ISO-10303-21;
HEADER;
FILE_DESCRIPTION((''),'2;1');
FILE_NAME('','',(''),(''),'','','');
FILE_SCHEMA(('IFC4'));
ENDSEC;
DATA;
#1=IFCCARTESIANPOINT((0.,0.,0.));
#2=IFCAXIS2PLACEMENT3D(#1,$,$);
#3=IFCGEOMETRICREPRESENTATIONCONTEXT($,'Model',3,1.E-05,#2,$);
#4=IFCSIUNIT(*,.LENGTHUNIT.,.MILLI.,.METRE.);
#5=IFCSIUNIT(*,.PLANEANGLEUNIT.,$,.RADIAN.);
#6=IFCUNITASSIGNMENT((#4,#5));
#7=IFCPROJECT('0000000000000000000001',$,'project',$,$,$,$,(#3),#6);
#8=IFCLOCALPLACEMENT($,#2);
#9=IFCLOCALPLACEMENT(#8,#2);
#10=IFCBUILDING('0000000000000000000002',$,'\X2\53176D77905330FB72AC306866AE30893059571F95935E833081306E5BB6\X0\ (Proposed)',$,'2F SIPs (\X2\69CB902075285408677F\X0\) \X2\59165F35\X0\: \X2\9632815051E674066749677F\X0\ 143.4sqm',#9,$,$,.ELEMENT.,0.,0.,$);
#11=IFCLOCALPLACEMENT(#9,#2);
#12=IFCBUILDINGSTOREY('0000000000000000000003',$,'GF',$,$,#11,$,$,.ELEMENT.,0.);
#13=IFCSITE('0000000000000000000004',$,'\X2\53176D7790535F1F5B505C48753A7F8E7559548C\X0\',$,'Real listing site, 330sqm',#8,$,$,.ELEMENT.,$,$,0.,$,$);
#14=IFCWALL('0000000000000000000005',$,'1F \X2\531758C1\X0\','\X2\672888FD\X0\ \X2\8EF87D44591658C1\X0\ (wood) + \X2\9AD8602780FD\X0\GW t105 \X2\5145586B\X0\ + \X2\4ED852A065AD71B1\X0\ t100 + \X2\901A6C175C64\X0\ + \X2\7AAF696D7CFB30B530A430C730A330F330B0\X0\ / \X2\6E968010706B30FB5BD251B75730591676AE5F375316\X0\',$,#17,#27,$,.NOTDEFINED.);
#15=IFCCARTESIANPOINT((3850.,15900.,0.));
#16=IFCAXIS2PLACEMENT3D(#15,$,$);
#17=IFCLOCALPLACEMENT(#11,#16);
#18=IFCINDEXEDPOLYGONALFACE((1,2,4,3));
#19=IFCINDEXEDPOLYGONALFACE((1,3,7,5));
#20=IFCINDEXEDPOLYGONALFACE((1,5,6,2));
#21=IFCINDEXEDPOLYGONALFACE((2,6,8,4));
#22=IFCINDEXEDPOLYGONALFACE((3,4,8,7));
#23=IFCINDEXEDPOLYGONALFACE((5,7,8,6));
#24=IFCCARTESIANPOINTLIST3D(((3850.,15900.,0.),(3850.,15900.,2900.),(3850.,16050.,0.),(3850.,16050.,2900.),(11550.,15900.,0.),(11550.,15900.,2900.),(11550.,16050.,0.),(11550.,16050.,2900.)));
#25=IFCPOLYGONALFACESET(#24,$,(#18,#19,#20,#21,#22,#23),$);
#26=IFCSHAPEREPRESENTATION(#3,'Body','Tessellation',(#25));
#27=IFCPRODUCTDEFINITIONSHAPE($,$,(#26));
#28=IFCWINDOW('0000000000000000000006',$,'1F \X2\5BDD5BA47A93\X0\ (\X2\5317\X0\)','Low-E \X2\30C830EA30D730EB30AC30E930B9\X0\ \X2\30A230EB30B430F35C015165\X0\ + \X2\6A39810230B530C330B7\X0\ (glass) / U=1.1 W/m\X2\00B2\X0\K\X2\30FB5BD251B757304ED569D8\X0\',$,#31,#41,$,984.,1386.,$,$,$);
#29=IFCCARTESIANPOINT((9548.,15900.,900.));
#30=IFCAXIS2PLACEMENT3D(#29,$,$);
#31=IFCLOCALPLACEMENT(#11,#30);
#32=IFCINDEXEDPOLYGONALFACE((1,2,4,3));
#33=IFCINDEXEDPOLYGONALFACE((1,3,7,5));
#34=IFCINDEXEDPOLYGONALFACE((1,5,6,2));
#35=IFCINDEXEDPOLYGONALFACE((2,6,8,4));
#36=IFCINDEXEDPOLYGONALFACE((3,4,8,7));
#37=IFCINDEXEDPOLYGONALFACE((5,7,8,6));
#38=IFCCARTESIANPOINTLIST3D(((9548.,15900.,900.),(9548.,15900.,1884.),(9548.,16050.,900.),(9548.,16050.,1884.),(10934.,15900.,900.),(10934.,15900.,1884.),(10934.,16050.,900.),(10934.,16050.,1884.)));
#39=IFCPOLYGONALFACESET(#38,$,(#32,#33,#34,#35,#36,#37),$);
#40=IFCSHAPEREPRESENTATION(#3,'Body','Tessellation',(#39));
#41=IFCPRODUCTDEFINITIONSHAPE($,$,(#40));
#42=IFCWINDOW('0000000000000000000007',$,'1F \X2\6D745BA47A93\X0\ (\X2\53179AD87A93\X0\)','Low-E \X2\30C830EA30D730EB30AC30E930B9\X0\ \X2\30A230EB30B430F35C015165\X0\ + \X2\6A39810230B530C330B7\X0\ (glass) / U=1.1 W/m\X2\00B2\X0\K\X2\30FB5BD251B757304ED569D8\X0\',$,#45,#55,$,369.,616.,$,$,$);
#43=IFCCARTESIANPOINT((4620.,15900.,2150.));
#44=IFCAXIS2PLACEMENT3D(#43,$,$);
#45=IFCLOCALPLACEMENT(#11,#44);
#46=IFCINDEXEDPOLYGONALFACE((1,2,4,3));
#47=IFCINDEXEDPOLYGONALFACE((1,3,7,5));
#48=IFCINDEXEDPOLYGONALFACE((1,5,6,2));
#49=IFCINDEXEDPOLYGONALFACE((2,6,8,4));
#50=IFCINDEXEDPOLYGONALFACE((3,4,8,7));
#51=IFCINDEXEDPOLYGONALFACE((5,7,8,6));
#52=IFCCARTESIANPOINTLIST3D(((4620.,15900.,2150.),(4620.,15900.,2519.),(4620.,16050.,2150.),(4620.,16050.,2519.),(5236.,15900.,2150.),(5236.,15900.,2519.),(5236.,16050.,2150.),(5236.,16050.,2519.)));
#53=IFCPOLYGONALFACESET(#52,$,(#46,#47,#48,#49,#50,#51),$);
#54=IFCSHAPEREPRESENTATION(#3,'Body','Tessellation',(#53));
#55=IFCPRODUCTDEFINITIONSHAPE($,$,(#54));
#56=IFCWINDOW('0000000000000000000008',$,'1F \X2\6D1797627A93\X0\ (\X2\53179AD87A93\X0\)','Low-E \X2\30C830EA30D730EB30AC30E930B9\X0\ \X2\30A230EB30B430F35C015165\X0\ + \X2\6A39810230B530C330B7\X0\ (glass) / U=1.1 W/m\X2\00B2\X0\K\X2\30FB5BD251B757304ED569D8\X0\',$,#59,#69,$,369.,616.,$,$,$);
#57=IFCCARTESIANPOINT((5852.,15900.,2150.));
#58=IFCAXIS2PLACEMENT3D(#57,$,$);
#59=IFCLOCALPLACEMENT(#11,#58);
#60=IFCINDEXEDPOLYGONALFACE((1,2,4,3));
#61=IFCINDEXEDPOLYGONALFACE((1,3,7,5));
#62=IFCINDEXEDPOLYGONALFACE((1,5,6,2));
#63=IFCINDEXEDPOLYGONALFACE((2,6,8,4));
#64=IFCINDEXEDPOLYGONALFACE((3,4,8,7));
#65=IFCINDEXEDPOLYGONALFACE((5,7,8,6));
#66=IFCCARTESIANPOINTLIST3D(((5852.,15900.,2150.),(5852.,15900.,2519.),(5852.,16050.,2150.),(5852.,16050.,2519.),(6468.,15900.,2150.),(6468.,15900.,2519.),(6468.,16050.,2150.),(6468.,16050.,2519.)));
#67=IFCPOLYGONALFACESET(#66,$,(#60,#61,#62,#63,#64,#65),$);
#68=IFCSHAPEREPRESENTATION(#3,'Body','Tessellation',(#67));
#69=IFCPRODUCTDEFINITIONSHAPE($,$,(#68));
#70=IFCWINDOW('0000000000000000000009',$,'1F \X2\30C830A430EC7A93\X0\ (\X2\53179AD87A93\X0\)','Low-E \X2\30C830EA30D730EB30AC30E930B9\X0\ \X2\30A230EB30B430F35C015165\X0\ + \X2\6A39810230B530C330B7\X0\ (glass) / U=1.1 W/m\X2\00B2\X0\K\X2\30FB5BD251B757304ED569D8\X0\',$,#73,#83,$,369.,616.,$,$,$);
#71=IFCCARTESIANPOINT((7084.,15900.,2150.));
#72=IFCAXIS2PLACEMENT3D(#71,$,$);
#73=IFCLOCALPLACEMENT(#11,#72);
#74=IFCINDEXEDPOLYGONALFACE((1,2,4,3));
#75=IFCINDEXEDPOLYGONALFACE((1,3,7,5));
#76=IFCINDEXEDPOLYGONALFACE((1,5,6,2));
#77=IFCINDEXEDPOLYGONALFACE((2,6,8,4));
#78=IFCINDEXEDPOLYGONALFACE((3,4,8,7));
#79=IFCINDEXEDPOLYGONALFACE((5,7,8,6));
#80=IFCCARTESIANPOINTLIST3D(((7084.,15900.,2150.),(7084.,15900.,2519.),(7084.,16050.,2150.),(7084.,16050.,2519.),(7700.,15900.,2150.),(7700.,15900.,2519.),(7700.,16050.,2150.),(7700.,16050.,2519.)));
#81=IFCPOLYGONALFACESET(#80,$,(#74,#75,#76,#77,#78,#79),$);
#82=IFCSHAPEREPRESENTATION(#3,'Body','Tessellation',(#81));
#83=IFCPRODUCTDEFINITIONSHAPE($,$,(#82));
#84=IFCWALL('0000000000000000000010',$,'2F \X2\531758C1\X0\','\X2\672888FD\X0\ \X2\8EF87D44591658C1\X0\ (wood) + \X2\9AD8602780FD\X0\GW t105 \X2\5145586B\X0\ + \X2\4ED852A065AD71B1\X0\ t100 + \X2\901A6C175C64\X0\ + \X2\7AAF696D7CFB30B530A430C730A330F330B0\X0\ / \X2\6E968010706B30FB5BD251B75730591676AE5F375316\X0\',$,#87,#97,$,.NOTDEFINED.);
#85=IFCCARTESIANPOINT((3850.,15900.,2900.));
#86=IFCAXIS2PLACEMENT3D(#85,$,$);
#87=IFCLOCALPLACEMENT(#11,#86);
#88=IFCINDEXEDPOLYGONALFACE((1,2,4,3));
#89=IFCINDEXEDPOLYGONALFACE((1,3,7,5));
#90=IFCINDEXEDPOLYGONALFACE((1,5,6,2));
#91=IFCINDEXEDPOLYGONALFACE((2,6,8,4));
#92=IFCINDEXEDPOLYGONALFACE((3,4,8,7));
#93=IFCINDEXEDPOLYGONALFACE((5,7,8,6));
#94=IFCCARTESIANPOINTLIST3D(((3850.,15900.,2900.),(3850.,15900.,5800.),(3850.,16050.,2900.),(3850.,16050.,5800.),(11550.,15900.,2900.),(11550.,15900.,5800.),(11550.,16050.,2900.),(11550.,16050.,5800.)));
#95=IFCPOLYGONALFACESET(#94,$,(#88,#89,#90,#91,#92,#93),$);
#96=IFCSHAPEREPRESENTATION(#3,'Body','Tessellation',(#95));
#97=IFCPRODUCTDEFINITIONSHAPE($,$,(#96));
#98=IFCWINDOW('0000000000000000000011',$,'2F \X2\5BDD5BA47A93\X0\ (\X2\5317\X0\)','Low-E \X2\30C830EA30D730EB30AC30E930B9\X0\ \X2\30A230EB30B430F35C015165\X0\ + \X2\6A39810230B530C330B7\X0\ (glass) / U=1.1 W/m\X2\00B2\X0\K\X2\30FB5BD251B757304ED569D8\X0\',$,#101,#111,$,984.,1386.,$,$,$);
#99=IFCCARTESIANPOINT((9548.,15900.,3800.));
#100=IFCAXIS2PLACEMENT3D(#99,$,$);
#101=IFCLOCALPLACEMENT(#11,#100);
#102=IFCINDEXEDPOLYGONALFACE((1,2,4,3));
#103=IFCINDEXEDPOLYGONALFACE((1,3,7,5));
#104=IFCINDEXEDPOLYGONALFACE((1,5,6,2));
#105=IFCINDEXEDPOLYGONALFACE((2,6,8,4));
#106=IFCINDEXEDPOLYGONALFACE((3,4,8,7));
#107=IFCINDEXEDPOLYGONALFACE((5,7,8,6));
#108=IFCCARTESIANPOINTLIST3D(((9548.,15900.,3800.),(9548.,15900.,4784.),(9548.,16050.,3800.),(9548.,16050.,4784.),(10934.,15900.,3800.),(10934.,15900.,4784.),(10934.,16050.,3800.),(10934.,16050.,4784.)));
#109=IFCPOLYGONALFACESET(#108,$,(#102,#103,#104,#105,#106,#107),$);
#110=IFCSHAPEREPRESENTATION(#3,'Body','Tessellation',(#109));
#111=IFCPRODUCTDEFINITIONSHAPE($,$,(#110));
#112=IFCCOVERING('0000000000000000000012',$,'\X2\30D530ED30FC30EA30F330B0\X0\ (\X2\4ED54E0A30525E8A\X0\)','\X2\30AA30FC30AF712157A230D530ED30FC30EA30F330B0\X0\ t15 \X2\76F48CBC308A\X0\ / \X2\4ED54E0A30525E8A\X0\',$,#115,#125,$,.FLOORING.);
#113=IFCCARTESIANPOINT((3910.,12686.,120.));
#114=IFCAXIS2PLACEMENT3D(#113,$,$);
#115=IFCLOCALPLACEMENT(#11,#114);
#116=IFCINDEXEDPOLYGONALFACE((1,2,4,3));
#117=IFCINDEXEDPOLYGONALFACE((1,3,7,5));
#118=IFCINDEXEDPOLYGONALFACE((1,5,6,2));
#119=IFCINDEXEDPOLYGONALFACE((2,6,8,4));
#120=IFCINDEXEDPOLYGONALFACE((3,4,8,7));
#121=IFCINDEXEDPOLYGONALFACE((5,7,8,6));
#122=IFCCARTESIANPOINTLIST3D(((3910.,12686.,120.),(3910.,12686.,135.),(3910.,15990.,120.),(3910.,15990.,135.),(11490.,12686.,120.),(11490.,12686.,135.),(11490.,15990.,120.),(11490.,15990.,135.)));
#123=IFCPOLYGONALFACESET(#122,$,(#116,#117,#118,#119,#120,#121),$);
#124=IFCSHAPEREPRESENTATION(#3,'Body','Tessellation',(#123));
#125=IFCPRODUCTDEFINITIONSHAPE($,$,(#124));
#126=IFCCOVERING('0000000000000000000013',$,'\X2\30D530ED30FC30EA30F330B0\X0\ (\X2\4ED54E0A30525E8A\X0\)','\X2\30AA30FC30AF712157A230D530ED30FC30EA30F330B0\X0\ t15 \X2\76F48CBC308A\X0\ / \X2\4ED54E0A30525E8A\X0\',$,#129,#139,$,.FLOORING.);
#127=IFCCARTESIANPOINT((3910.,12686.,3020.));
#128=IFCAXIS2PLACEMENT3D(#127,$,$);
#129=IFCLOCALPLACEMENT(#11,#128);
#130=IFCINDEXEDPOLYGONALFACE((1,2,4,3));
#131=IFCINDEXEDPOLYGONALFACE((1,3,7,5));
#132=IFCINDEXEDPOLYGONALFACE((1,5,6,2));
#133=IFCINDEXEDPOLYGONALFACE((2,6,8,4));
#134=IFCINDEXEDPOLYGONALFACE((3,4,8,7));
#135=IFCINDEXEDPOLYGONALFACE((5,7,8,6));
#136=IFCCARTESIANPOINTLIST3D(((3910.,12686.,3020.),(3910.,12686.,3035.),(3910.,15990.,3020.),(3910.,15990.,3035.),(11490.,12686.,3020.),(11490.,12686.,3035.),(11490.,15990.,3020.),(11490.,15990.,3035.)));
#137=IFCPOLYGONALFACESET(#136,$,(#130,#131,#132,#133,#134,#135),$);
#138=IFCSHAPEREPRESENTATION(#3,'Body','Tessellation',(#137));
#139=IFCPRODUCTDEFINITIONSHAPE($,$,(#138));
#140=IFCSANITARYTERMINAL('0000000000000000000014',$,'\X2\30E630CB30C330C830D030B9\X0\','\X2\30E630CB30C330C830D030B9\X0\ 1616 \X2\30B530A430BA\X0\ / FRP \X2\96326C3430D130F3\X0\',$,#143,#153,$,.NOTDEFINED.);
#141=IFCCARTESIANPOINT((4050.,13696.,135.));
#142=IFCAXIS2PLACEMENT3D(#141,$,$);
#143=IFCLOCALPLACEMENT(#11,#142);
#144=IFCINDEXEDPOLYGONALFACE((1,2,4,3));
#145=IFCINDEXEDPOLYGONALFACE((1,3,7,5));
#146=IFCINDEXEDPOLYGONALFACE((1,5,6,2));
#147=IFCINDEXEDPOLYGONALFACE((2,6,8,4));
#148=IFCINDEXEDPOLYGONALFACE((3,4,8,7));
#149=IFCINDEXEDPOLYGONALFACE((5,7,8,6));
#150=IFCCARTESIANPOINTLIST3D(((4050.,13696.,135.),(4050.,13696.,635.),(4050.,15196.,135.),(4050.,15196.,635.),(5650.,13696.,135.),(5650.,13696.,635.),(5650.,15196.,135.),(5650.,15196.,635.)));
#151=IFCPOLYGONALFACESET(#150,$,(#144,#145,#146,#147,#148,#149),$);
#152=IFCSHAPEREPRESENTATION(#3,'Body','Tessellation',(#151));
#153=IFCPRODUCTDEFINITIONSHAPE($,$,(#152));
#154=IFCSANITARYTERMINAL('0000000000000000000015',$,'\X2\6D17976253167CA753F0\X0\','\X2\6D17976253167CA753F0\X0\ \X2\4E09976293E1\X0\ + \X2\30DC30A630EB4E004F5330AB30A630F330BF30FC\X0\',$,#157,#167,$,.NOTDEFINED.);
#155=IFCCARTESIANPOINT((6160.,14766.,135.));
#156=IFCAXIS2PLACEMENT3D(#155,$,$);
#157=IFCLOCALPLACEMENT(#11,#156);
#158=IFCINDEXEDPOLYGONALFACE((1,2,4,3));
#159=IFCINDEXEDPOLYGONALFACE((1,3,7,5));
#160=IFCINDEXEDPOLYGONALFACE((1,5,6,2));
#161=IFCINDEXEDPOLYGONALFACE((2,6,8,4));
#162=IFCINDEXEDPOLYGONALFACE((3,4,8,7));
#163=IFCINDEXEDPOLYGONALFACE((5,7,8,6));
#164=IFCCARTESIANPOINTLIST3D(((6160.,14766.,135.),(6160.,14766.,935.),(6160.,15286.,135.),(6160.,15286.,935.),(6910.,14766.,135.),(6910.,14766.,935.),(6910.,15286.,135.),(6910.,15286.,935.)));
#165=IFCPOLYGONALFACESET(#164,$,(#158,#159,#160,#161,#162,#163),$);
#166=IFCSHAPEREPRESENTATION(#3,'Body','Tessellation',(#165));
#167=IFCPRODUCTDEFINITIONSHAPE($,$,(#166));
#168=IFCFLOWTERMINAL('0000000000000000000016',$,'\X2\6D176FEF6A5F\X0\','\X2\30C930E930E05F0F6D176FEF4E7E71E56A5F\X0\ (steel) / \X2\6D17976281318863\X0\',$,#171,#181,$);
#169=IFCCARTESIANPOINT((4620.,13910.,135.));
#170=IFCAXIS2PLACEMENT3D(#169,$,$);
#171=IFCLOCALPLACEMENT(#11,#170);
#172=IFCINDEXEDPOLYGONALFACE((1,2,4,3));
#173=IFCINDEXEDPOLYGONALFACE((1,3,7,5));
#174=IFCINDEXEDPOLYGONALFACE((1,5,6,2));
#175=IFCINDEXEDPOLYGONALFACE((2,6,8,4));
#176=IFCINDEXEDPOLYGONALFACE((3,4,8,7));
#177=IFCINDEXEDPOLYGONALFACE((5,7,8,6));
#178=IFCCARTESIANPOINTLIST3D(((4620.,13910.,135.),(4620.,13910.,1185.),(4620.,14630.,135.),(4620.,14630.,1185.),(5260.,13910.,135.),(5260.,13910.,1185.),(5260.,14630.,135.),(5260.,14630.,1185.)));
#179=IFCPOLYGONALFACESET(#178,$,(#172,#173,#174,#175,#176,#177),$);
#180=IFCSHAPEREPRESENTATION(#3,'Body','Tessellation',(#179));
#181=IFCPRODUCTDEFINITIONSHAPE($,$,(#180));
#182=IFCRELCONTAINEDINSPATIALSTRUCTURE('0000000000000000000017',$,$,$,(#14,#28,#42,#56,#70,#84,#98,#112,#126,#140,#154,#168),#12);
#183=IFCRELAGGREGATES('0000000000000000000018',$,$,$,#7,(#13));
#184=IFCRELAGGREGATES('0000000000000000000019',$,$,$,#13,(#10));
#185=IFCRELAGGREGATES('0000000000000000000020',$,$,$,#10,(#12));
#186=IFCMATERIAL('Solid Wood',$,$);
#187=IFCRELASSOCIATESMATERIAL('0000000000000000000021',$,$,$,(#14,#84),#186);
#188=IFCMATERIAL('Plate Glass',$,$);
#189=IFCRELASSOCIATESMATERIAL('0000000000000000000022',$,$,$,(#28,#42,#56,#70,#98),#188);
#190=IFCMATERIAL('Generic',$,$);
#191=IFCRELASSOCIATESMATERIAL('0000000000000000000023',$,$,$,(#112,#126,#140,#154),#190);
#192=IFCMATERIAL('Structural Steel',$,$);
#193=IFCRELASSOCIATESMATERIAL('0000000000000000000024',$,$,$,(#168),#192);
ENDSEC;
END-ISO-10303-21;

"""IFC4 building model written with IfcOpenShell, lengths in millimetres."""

from ifc_helpers import new_model, si_unit, frame, frame_2d, origin, place, context, project, spatial, rectangle, extrude, material, element, fill, save


model = new_model("IFC4")

# Units and contexts
model_context = context("Model", 3, precision=1e-05, world=origin())
ifc_project = project(units=[si_unit("LENGTHUNIT", "METRE", prefix="MILLI"), si_unit("PLANEANGLEUNIT", "RADIAN")], contexts=[model_context])

# Site, building, storey
site_placement = place(None, origin())
site = spatial("IfcSite", under=ifc_project, at=site_placement, Name="北海道弟子屈町美留和", ObjectType="Real listing site, 330sqm", CompositionType="ELEMENT", RefElevation=0.0)
building_placement = place(site_placement, origin())
building = spatial("IfcBuilding", under=site, at=building_placement, Name="北海道・犬と暮らす土間広めの家 (Proposed)", ObjectType="2F SIPs (構造用合板) 外張: 防腐処理杉板 143.4sqm", CompositionType="ELEMENT", ElevationOfRefHeight=0.0, ElevationOfTerrain=0.0)
storey_placement = place(building_placement, origin())
storey = spatial("IfcBuildingStorey", under=building, at=storey_placement, Name="GF", CompositionType="ELEMENT", Elevation=0.0)

# Shared definitions
ifc_material_1 = material(Name="Solid Wood")

# Wall, openings, windows
wall_1_placement = place(storey_placement, frame((3850.0, 15900.0, 0.0)))
wall_1 = element("IfcWall", 1, at=wall_1_placement, inside=storey, material=ifc_material_1, Name="1F 北壁", Description="木製 軸組外壁 (wood) + 高性能GW t105 充填 + 付加断熱 t100 + 通気層 + 窯業系サイディング / 準耐火・寒冷地外皮強化", PredefinedType="NOTDEFINED", context=model_context, shape_type="SweptSolid", body=[
    extrude(rectangle(XDim=7700.0, YDim=150.0, at=frame_2d((3850.0, 75.0))), frame((3850.0, 15900.0, 0.0)), (0.0, 0.0, 1.0), 2900.0),
])
opening_1_placement = place(storey_placement, frame((9548.0, 15900.0, 900.0)))
opening_1 = element("IfcOpeningElement", 2, at=opening_1_placement, cuts=wall_1, PredefinedType="NOTDEFINED", context=model_context, shape_type="SweptSolid", body=[
    extrude(rectangle(XDim=1386.0, YDim=150.0, at=frame_2d((693.0, 75.0))), frame((9548.0, 15900.0, 900.0)), (0.0, 0.0, 1.0), 984.0),
])
opening_2_placement = place(storey_placement, frame((4620.0, 15900.0, 2150.0)))
opening_2 = element("IfcOpeningElement", 3, at=opening_2_placement, cuts=wall_1, PredefinedType="NOTDEFINED", context=model_context, shape_type="SweptSolid", body=[
    extrude(rectangle(XDim=616.0, YDim=150.0, at=frame_2d((308.0, 75.0))), frame((4620.0, 15900.0, 2150.0)), (0.0, 0.0, 1.0), 369.0),
])
opening_3_placement = place(storey_placement, frame((5852.0, 15900.0, 2150.0)))
opening_3 = element("IfcOpeningElement", 4, at=opening_3_placement, cuts=wall_1, PredefinedType="NOTDEFINED", context=model_context, shape_type="SweptSolid", body=[
    extrude(rectangle(XDim=616.0, YDim=150.0, at=frame_2d((308.0, 75.0))), frame((5852.0, 15900.0, 2150.0)), (0.0, 0.0, 1.0), 369.0),
])
opening_4_placement = place(storey_placement, frame((7084.0, 15900.0, 2150.0)))
opening_4 = element("IfcOpeningElement", 5, at=opening_4_placement, cuts=wall_1, PredefinedType="NOTDEFINED", context=model_context, shape_type="SweptSolid", body=[
    extrude(rectangle(XDim=616.0, YDim=150.0, at=frame_2d((308.0, 75.0))), frame((7084.0, 15900.0, 2150.0)), (0.0, 0.0, 1.0), 369.0),
])
ifc_material_2 = material(Name="Plate Glass")
window_1_placement = place(storey_placement, frame((9548.0, 15900.0, 900.0)))
window_1 = element("IfcWindow", 6, at=window_1_placement, inside=storey, material=ifc_material_2, Name="1F 寝室窓 (北)", Description="Low-E トリプルガラス アルゴン封入 + 樹脂サッシ (glass) / U=1.1 W/m²K・寒冷地仕様", OverallHeight=984.0, OverallWidth=1386.0, context=model_context, shape_type="SweptSolid", body=[
    extrude(rectangle(XDim=1386.0, YDim=150.0, at=frame_2d((693.0, 75.0))), frame((9548.0, 15900.0, 900.0)), (0.0, 0.0, 1.0), 984.0),
])
fill(opening_1, window_1)
window_2_placement = place(storey_placement, frame((4620.0, 15900.0, 2150.0)))
window_2 = element("IfcWindow", 7, at=window_2_placement, inside=storey, material=ifc_material_2, Name="1F 浴室窓 (北高窓)", Description="Low-E トリプルガラス アルゴン封入 + 樹脂サッシ (glass) / U=1.1 W/m²K・寒冷地仕様", OverallHeight=369.0, OverallWidth=616.0, context=model_context, shape_type="SweptSolid", body=[
    extrude(rectangle(XDim=616.0, YDim=150.0, at=frame_2d((308.0, 75.0))), frame((4620.0, 15900.0, 2150.0)), (0.0, 0.0, 1.0), 369.0),
])
fill(opening_2, window_2)
window_3_placement = place(storey_placement, frame((5852.0, 15900.0, 2150.0)))
window_3 = element("IfcWindow", 8, at=window_3_placement, inside=storey, material=ifc_material_2, Name="1F 洗面窓 (北高窓)", Description="Low-E トリプルガラス アルゴン封入 + 樹脂サッシ (glass) / U=1.1 W/m²K・寒冷地仕様", OverallHeight=369.0, OverallWidth=616.0, context=model_context, shape_type="SweptSolid", body=[
    extrude(rectangle(XDim=616.0, YDim=150.0, at=frame_2d((308.0, 75.0))), frame((5852.0, 15900.0, 2150.0)), (0.0, 0.0, 1.0), 369.0),
])
fill(opening_3, window_3)
window_4_placement = place(storey_placement, frame((7084.0, 15900.0, 2150.0)))
window_4 = element("IfcWindow", 9, at=window_4_placement, inside=storey, material=ifc_material_2, Name="1F トイレ窓 (北高窓)", Description="Low-E トリプルガラス アルゴン封入 + 樹脂サッシ (glass) / U=1.1 W/m²K・寒冷地仕様", OverallHeight=369.0, OverallWidth=616.0, context=model_context, shape_type="SweptSolid", body=[
    extrude(rectangle(XDim=616.0, YDim=150.0, at=frame_2d((308.0, 75.0))), frame((7084.0, 15900.0, 2150.0)), (0.0, 0.0, 1.0), 369.0),
])
fill(opening_4, window_4)

# Wall, opening, window
wall_2_placement = place(storey_placement, frame((3850.0, 15900.0, 2900.0)))
wall_2 = element("IfcWall", 10, at=wall_2_placement, inside=storey, material=ifc_material_1, Name="2F 北壁", Description="木製 軸組外壁 (wood) + 高性能GW t105 充填 + 付加断熱 t100 + 通気層 + 窯業系サイディング / 準耐火・寒冷地外皮強化", PredefinedType="NOTDEFINED", context=model_context, shape_type="SweptSolid", body=[
    extrude(rectangle(XDim=7700.0, YDim=150.0, at=frame_2d((3850.0, 75.0))), frame((3850.0, 15900.0, 2900.0)), (0.0, 0.0, 1.0), 2900.0),
])
opening_5_placement = place(storey_placement, frame((9548.0, 15900.0, 3800.0)))
opening_5 = element("IfcOpeningElement", 11, at=opening_5_placement, cuts=wall_2, PredefinedType="NOTDEFINED", context=model_context, shape_type="SweptSolid", body=[
    extrude(rectangle(XDim=1386.0, YDim=150.0, at=frame_2d((693.0, 75.0))), frame((9548.0, 15900.0, 3800.0)), (0.0, 0.0, 1.0), 984.0),
])
window_5_placement = place(storey_placement, frame((9548.0, 15900.0, 3800.0)))
window_5 = element("IfcWindow", 12, at=window_5_placement, inside=storey, material=ifc_material_2, Name="2F 寝室窓 (北)", Description="Low-E トリプルガラス アルゴン封入 + 樹脂サッシ (glass) / U=1.1 W/m²K・寒冷地仕様", OverallHeight=984.0, OverallWidth=1386.0, context=model_context, shape_type="SweptSolid", body=[
    extrude(rectangle(XDim=1386.0, YDim=150.0, at=frame_2d((693.0, 75.0))), frame((9548.0, 15900.0, 3800.0)), (0.0, 0.0, 1.0), 984.0),
])
fill(opening_5, window_5)

# Coverings
ifc_material_3 = material(Name="Generic")
covering_1_placement = place(storey_placement, frame((3910.0, 12686.0, 120.0)))
element("IfcCovering", 13, at=covering_1_placement, inside=storey, material=ifc_material_3, Name="フローリング (仕上げ床)", Description="オーク無垢フローリング t15 直貼り / 仕上げ床", PredefinedType="FLOORING", context=model_context, shape_type="SweptSolid", body=[
    extrude(rectangle(XDim=7580.0, YDim=3304.0, at=frame_2d((3790.0, 1652.0))), frame((3910.0, 12686.0, 120.0)), (0.0, 0.0, 1.0), 15.0),
])
covering_2_placement = place(storey_placement, frame((3910.0, 12686.0, 3020.0)))
element("IfcCovering", 14, at=covering_2_placement, inside=storey, material=ifc_material_3, Name="フローリング (仕上げ床)", Description="オーク無垢フローリング t15 直貼り / 仕上げ床", PredefinedType="FLOORING", context=model_context, shape_type="SweptSolid", body=[
    extrude(rectangle(XDim=7580.0, YDim=3304.0, at=frame_2d((3790.0, 1652.0))), frame((3910.0, 12686.0, 3020.0)), (0.0, 0.0, 1.0), 15.0),
])

# Sanitary terminals
sanitary_terminal_1_placement = place(storey_placement, frame((4050.0, 13696.0, 135.0)))
element("IfcSanitaryTerminal", 15, at=sanitary_terminal_1_placement, inside=storey, material=ifc_material_3, Name="ユニットバス", Description="ユニットバス 1616 サイズ / FRP 防水パン", PredefinedType="NOTDEFINED", context=model_context, shape_type="SweptSolid", body=[
    extrude(rectangle(XDim=1600.0, YDim=1500.0, at=frame_2d((800.0, 750.0))), frame((4050.0, 13696.0, 135.0)), (0.0, 0.0, 1.0), 500.0),
])
sanitary_terminal_2_placement = place(storey_placement, frame((6160.0, 14766.0, 135.0)))
element("IfcSanitaryTerminal", 16, at=sanitary_terminal_2_placement, inside=storey, material=ifc_material_3, Name="洗面化粧台", Description="洗面化粧台 三面鏡 + ボウル一体カウンター", PredefinedType="NOTDEFINED", context=model_context, shape_type="SweptSolid", body=[
    extrude(rectangle(XDim=750.0, YDim=520.0, at=frame_2d((375.0, 260.0))), frame((6160.0, 14766.0, 135.0)), (0.0, 0.0, 1.0), 800.0),
])

# Flow terminal
ifc_material_4 = material(Name="Structural Steel")
flow_terminal_placement = place(storey_placement, frame((4620.0, 13910.0, 135.0)))
element("IfcFlowTerminal", 17, at=flow_terminal_placement, inside=storey, material=ifc_material_4, Name="洗濯機", Description="ドラム式洗濯乾燥機 (steel) / 洗面脱衣", context=model_context, shape_type="SweptSolid", body=[
    extrude(rectangle(XDim=640.0, YDim=720.0, at=frame_2d((320.0, 360.0))), frame((4620.0, 13910.0, 135.0)), (0.0, 0.0, 1.0), 1050.0),
])

save(model, "model.ifc")
